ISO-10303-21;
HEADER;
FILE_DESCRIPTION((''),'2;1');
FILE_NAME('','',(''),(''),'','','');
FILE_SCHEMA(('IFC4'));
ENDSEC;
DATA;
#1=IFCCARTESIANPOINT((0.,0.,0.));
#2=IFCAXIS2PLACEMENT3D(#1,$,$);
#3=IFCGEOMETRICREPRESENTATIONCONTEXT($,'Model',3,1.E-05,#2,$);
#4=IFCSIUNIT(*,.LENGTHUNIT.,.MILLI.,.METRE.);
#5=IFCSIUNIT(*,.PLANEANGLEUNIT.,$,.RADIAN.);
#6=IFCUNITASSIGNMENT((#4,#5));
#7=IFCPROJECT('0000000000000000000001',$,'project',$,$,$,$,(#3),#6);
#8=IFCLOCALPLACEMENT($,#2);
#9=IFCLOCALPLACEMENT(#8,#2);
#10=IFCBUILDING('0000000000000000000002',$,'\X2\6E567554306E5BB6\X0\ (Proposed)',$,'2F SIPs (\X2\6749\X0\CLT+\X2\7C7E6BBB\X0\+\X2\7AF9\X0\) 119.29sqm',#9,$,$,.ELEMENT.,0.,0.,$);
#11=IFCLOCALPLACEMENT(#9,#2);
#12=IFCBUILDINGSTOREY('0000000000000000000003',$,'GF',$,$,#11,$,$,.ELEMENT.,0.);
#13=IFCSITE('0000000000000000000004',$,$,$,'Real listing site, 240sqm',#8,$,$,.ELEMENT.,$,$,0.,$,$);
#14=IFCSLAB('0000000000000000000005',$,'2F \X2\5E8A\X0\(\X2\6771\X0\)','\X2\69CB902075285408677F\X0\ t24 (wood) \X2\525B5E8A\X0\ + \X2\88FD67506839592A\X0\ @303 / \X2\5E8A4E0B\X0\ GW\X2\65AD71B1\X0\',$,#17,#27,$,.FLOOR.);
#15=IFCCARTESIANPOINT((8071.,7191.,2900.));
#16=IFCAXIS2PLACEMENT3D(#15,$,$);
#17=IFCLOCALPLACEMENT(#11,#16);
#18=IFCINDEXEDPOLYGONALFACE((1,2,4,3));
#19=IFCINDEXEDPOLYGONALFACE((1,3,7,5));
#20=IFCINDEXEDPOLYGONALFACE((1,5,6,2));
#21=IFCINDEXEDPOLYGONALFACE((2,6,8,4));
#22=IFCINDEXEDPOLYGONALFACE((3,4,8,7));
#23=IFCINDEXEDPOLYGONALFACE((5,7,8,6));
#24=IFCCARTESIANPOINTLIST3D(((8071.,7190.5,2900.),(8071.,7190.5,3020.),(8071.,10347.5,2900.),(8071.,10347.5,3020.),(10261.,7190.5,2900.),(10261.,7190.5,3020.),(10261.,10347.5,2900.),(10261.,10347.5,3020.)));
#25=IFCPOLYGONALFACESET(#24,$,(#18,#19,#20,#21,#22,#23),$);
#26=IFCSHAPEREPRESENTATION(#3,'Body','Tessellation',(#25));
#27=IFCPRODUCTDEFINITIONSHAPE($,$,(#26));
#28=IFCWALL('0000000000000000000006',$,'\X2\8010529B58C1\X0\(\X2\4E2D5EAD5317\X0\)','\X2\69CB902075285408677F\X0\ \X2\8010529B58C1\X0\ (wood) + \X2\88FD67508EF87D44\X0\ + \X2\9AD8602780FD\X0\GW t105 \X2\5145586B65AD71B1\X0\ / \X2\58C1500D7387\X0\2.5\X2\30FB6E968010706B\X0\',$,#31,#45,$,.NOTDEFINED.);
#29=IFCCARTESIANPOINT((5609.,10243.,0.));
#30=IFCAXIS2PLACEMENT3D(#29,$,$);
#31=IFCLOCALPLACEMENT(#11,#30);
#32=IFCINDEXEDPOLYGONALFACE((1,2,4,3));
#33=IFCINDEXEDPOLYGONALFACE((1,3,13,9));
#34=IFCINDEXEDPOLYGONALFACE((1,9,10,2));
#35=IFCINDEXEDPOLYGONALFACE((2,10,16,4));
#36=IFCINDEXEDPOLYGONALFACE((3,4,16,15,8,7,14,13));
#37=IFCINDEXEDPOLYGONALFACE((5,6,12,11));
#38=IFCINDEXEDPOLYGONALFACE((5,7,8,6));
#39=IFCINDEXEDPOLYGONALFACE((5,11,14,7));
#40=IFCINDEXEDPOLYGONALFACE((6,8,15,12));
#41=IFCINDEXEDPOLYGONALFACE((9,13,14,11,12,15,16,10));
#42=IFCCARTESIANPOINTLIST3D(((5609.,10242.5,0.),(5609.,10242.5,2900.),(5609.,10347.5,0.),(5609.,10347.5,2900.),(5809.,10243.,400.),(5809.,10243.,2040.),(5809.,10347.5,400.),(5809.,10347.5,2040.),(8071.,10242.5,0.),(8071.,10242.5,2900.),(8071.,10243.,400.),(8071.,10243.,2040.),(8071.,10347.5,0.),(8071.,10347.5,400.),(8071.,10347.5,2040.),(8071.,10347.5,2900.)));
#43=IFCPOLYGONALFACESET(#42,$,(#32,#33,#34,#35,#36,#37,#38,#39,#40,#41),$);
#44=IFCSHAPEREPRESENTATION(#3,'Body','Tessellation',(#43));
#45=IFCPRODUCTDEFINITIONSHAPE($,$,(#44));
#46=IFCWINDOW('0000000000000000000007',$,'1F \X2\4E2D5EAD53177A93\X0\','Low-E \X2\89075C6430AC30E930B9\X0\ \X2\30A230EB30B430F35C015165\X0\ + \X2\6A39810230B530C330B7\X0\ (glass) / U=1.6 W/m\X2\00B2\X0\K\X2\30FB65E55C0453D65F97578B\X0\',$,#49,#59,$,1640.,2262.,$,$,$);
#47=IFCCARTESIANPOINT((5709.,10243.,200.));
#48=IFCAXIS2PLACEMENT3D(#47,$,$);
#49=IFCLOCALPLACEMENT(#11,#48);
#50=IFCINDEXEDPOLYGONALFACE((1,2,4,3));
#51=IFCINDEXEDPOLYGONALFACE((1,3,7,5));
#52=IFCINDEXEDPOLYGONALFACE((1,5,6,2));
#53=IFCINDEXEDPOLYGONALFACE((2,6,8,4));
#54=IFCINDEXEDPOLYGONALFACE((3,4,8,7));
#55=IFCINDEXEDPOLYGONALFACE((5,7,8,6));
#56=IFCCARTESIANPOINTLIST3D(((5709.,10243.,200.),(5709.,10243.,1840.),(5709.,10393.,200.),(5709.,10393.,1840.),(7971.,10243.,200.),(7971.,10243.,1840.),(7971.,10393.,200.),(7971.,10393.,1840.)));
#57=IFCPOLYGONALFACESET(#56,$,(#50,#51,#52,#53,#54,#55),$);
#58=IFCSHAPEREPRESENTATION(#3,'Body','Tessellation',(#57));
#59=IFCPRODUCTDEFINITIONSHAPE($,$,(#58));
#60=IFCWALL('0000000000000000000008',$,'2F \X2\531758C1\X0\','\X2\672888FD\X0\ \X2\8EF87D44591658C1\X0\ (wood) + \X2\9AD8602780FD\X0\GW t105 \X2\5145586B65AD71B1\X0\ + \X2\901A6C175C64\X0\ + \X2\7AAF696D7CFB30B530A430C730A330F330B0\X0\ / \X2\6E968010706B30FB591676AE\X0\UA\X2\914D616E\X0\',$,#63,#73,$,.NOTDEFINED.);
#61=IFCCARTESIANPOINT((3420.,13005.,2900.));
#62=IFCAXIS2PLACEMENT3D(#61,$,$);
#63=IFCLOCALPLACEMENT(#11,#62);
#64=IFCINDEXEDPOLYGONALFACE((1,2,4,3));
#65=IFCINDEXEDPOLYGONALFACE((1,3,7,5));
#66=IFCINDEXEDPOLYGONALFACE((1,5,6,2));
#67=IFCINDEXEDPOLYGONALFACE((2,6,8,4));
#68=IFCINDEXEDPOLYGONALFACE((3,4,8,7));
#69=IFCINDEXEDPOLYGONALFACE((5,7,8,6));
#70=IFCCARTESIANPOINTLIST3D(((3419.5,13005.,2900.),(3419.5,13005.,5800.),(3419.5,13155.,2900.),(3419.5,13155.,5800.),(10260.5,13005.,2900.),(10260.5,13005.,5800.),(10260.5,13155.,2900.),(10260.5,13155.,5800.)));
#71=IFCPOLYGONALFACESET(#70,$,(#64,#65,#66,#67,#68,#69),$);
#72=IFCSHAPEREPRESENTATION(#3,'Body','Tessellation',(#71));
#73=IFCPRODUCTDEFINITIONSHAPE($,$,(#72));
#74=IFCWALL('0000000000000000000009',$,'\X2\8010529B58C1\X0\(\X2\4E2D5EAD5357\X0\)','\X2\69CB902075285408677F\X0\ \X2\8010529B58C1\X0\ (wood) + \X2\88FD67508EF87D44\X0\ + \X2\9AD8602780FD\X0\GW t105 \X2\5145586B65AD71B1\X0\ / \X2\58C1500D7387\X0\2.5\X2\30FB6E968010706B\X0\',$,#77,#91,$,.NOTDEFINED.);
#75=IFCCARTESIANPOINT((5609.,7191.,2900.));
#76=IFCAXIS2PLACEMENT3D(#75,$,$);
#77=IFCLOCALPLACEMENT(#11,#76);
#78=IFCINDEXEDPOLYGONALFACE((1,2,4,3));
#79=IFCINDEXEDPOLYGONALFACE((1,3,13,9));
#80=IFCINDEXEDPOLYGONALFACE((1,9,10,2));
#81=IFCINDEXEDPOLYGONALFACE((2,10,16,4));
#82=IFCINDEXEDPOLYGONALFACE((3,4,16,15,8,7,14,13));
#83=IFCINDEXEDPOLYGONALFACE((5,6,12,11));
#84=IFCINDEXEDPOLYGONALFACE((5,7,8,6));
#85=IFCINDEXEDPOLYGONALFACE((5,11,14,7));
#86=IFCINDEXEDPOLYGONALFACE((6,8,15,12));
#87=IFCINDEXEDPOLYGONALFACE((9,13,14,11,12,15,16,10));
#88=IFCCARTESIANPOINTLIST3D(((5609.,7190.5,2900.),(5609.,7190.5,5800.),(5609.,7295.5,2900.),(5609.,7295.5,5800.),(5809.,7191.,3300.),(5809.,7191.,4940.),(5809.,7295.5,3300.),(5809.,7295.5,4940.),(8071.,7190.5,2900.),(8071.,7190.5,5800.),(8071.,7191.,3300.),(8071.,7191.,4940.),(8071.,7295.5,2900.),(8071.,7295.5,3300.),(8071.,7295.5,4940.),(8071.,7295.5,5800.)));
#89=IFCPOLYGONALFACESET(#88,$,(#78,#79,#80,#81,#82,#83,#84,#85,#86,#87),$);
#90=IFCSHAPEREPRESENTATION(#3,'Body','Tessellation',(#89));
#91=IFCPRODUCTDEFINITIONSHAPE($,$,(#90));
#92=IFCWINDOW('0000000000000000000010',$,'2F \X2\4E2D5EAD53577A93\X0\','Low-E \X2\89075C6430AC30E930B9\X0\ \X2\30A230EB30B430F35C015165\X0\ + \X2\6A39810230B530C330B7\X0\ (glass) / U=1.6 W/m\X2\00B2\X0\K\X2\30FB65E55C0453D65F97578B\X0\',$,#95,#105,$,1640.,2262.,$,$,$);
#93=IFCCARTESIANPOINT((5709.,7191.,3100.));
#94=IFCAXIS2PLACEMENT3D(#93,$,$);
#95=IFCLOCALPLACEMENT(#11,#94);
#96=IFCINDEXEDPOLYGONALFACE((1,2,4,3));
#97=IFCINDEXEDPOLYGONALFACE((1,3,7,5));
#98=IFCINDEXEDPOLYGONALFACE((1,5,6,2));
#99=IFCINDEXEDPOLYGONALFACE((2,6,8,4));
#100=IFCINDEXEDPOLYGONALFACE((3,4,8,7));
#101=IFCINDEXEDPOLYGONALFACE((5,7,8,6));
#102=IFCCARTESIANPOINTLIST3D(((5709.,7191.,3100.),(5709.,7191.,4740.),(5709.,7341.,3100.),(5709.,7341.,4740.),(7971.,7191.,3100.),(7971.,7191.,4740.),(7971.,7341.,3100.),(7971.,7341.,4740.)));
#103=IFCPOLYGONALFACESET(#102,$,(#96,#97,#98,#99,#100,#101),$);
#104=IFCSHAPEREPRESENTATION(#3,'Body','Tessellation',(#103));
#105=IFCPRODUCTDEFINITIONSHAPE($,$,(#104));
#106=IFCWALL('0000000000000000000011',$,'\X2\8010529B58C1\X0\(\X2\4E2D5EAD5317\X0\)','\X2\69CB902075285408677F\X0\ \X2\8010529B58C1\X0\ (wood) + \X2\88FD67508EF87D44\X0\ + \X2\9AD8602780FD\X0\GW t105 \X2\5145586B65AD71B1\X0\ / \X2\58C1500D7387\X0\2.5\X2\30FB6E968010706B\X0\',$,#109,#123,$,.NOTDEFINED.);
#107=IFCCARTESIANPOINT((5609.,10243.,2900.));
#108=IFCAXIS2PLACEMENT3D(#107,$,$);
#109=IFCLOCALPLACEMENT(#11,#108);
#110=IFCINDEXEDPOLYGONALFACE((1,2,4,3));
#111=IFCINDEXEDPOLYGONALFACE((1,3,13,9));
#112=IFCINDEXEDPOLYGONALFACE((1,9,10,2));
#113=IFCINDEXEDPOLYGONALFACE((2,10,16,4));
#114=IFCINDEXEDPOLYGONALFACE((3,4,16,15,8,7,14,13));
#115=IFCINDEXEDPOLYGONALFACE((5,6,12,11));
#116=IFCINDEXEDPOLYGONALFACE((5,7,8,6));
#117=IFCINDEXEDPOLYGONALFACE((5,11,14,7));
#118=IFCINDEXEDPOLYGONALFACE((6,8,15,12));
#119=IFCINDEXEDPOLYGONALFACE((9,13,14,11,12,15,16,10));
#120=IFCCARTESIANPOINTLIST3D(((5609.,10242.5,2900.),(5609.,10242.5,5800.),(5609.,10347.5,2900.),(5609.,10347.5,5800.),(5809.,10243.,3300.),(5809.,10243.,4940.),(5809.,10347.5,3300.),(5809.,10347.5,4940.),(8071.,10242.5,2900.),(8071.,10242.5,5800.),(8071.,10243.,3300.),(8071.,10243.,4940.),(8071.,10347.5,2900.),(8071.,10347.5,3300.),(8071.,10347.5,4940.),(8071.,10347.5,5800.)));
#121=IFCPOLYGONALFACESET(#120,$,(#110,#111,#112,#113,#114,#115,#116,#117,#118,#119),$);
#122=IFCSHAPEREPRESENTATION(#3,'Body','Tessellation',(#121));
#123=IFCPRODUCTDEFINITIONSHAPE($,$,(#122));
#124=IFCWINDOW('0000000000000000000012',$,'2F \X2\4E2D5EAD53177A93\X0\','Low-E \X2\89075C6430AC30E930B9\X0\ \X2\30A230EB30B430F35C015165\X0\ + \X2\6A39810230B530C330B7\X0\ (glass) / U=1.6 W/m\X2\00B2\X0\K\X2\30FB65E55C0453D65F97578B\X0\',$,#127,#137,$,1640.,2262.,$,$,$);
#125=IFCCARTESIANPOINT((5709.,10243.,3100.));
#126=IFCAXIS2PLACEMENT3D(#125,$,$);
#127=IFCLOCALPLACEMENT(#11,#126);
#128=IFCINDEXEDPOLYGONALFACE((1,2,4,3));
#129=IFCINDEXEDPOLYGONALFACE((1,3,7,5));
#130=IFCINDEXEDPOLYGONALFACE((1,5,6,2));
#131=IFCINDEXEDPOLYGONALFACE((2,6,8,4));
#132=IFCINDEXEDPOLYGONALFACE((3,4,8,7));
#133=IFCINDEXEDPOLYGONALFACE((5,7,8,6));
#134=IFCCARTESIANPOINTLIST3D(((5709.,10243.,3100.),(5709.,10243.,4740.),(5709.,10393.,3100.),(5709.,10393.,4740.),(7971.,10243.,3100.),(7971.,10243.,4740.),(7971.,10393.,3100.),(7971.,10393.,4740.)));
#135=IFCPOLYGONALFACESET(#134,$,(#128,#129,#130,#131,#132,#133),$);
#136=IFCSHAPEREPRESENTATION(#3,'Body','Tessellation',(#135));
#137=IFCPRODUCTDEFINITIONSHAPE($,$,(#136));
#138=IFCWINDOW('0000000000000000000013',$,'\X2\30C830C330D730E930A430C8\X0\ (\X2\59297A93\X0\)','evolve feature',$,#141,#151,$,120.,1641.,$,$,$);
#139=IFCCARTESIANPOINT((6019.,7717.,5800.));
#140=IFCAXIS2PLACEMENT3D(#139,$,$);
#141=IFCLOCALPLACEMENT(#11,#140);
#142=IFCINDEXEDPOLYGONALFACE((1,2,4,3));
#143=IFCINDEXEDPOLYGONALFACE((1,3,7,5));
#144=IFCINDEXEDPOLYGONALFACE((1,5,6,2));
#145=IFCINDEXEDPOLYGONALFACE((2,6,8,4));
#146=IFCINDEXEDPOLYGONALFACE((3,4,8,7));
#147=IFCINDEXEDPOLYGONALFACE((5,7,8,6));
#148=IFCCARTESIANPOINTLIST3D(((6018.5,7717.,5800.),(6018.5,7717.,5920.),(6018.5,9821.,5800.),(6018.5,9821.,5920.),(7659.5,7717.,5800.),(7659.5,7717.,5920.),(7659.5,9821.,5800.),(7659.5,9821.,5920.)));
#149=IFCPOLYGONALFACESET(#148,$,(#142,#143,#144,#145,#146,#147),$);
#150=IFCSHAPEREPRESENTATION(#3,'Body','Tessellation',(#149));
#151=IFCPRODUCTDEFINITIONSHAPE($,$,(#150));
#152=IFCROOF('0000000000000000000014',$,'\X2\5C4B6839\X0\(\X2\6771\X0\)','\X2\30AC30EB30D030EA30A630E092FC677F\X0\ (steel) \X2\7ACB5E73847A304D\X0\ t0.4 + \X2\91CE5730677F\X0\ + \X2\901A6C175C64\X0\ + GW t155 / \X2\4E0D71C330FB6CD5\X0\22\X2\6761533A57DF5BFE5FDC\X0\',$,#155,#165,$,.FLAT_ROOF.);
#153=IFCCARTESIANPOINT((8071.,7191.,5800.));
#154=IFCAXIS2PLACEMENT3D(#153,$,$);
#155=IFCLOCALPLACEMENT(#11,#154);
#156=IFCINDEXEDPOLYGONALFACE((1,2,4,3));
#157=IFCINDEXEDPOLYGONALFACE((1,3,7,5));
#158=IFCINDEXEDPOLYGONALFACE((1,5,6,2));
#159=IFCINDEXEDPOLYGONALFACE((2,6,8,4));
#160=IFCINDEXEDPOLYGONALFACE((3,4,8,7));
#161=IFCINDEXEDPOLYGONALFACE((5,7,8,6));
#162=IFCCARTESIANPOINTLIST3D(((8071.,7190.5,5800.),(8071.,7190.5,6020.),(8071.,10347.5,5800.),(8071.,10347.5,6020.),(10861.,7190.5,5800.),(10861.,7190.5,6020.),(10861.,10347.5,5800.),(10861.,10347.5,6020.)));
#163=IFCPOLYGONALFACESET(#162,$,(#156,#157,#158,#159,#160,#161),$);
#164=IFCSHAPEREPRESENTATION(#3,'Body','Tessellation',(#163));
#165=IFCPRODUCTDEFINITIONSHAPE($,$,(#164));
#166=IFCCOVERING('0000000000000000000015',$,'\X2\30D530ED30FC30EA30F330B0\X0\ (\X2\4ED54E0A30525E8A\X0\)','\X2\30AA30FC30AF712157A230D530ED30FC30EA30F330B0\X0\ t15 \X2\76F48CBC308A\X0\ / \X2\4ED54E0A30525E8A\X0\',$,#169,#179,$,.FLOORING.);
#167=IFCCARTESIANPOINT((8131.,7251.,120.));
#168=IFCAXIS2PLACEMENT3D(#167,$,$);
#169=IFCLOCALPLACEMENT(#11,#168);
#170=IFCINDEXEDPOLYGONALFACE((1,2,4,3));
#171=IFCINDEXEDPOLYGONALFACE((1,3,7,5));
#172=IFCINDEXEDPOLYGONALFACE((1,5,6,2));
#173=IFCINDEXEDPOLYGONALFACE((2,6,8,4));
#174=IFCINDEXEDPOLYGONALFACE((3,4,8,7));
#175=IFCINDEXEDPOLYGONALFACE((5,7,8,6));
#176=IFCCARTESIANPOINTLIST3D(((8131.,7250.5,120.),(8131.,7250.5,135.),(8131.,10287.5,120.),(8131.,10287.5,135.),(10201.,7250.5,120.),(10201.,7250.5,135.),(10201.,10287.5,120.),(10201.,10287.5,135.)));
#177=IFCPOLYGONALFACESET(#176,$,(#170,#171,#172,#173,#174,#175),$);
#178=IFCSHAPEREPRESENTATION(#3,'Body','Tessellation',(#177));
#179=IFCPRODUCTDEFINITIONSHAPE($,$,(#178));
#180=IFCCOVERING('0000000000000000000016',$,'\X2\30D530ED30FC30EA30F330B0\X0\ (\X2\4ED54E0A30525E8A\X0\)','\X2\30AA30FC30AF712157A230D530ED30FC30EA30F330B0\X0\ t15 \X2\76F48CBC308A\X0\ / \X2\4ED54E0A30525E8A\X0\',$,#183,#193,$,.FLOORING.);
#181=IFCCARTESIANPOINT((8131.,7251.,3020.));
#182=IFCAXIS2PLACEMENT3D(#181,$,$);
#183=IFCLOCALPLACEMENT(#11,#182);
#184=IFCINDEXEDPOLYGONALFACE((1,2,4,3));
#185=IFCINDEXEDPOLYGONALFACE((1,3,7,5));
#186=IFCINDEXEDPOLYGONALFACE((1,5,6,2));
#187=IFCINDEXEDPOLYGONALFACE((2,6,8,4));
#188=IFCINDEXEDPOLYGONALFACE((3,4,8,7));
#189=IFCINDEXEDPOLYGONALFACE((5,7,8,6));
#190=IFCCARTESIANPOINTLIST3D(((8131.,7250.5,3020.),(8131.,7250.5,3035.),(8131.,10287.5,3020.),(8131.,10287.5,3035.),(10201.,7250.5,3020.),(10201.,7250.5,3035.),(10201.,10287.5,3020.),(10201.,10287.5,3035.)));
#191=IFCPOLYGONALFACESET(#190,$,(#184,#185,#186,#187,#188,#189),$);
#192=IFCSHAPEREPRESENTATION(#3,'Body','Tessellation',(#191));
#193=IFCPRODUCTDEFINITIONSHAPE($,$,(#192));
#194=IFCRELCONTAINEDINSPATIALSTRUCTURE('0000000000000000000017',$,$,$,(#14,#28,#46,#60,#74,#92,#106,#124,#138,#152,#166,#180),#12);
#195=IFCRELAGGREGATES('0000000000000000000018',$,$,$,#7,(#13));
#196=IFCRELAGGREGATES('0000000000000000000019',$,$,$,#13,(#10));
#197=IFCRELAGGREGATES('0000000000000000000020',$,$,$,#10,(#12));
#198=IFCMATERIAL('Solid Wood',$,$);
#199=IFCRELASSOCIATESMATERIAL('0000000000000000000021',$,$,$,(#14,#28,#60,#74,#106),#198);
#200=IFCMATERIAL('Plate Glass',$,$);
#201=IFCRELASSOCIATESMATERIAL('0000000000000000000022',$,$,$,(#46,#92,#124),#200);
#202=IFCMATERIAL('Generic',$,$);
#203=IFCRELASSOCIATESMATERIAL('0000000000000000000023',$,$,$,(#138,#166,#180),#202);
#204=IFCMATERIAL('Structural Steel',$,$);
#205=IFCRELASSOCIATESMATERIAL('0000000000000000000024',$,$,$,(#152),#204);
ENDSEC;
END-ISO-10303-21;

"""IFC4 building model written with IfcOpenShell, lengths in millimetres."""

from ifc_helpers import new_model, si_unit, frame, frame_2d, origin, place, context, project, spatial, rectangle, extrude, material, element, fill, save


model = new_model("IFC4")

# Units and contexts
model_context = context("Model", 3, precision=1e-05, world=origin())
ifc_project = project(units=[si_unit("LENGTHUNIT", "METRE", prefix="MILLI"), si_unit("PLANEANGLEUNIT", "RADIAN")], contexts=[model_context])

# Site, building, storey
site_placement = place(None, origin())
site = spatial("IfcSite", under=ifc_project, at=site_placement, ObjectType="Real listing site, 240sqm", CompositionType="ELEMENT", RefElevation=0.0)
building_placement = place(site_placement, origin())
building = spatial("IfcBuilding", under=site, at=building_placement, Name="湖畔の家 (Proposed)", ObjectType="2F SIPs (杉CLT+籾殻+竹) 119.29sqm", CompositionType="ELEMENT", ElevationOfRefHeight=0.0, ElevationOfTerrain=0.0)
storey_placement = place(building_placement, origin())
storey = spatial("IfcBuildingStorey", under=building, at=storey_placement, Name="GF", CompositionType="ELEMENT", Elevation=0.0)

# Slab
ifc_material_1 = material(Name="Solid Wood")
slab_1_placement = place(storey_placement, frame((8071.0, 7191.0, 2900.0)))
element("IfcSlab", 1, at=slab_1_placement, inside=storey, material=ifc_material_1, Name="2F 床(東)", Description="構造用合板 t24 (wood) 剛床 + 製材根太 @303 / 床下 GW断熱", PredefinedType="FLOOR", context=model_context, shape_type="SweptSolid", body=[
    extrude(rectangle(XDim=2190.0, YDim=3157.0, at=frame_2d((1095.0, 1578.0))), frame((8071.0, 7191.0, 2900.0)), (0.0, 0.0, 1.0), 120.0),
])

# Wall, opening, window
wall_1_placement = place(storey_placement, frame((5609.0, 10243.0, 0.0)))
wall_1 = element("IfcWall", 2, at=wall_1_placement, inside=storey, material=ifc_material_1, Name="耐力壁(中庭北)", Description="構造用合板 耐力壁 (wood) + 製材軸組 + 高性能GW t105 充填断熱 / 壁倍率2.5・準耐火", PredefinedType="NOTDEFINED", context=model_context, shape_type="SweptSolid", body=[
    extrude(rectangle(XDim=2462.0, YDim=105.0, at=frame_2d((1231.0, 52.0))), frame((5609.0, 10243.0, 0.0)), (0.0, 0.0, 1.0), 2900.0),
])
opening_1_placement = place(storey_placement, frame((5709.0, 10243.0, 200.0)))
opening_1 = element("IfcOpeningElement", 3, at=opening_1_placement, cuts=wall_1, PredefinedType="NOTDEFINED", context=model_context, shape_type="SweptSolid", body=[
    extrude(rectangle(XDim=2262.0, YDim=150.0, at=frame_2d((1131.0, 75.0))), frame((5709.0, 10243.0, 200.0)), (0.0, 0.0, 1.0), 1640.0),
])
ifc_material_2 = material(Name="Plate Glass")
window_1_placement = place(storey_placement, frame((5709.0, 10243.0, 200.0)))
window_1 = element("IfcWindow", 4, at=window_1_placement, inside=storey, material=ifc_material_2, Name="1F 中庭北窓", Description="Low-E 複層ガラス アルゴン封入 + 樹脂サッシ (glass) / U=1.6 W/m²K・日射取得型", OverallHeight=1640.0, OverallWidth=2262.0, context=model_context, shape_type="SweptSolid", body=[
    extrude(rectangle(XDim=2262.0, YDim=150.0, at=frame_2d((1131.0, 75.0))), frame((5709.0, 10243.0, 200.0)), (0.0, 0.0, 1.0), 1640.0),
])
fill(opening_1, window_1)

# Wall
wall_2_placement = place(storey_placement, frame((3420.0, 13005.0, 2900.0)))
element("IfcWall", 5, at=wall_2_placement, inside=storey, material=ifc_material_1, Name="2F 北壁", Description="木製 軸組外壁 (wood) + 高性能GW t105 充填断熱 + 通気層 + 窯業系サイディング / 準耐火・外皮UA配慮", PredefinedType="NOTDEFINED", context=model_context, shape_type="SweptSolid", body=[
    extrude(rectangle(XDim=6841.0, YDim=150.0, at=frame_2d((3420.0, 75.0))), frame((3420.0, 13005.0, 2900.0)), (0.0, 0.0, 1.0), 2900.0),
])

# Walls, openings, windows
wall_3_placement = place(storey_placement, frame((5609.0, 7191.0, 2900.0)))
wall_3 = element("IfcWall", 6, at=wall_3_placement, inside=storey, material=ifc_material_1, Name="耐力壁(中庭南)", Description="構造用合板 耐力壁 (wood) + 製材軸組 + 高性能GW t105 充填断熱 / 壁倍率2.5・準耐火", PredefinedType="NOTDEFINED", context=model_context, shape_type="SweptSolid", body=[
    extrude(rectangle(XDim=2462.0, YDim=105.0, at=frame_2d((1231.0, 52.0))), frame((5609.0, 7191.0, 2900.0)), (0.0, 0.0, 1.0), 2900.0),
])
opening_2_placement = place(storey_placement, frame((5709.0, 7191.0, 3100.0)))
opening_2 = element("IfcOpeningElement", 7, at=opening_2_placement, cuts=wall_3, PredefinedType="NOTDEFINED", context=model_context, shape_type="SweptSolid", body=[
    extrude(rectangle(XDim=2262.0, YDim=150.0, at=frame_2d((1131.0, 75.0))), frame((5709.0, 7191.0, 3100.0)), (0.0, 0.0, 1.0), 1640.0),
])
window_2_placement = place(storey_placement, frame((5709.0, 7191.0, 3100.0)))
window_2 = element("IfcWindow", 8, at=window_2_placement, inside=storey, material=ifc_material_2, Name="2F 中庭南窓", Description="Low-E 複層ガラス アルゴン封入 + 樹脂サッシ (glass) / U=1.6 W/m²K・日射取得型", OverallHeight=1640.0, OverallWidth=2262.0, context=model_context, shape_type="SweptSolid", body=[
    extrude(rectangle(XDim=2262.0, YDim=150.0, at=frame_2d((1131.0, 75.0))), frame((5709.0, 7191.0, 3100.0)), (0.0, 0.0, 1.0), 1640.0),
])
fill(opening_2, window_2)
wall_4_placement = place(storey_placement, frame((5609.0, 10243.0, 2900.0)))
wall_4 = element("IfcWall", 9, at=wall_4_placement, inside=storey, material=ifc_material_1, Name="耐力壁(中庭北)", Description="構造用合板 耐力壁 (wood) + 製材軸組 + 高性能GW t105 充填断熱 / 壁倍率2.5・準耐火", PredefinedType="NOTDEFINED", context=model_context, shape_type="SweptSolid", body=[
    extrude(rectangle(XDim=2462.0, YDim=105.0, at=frame_2d((1231.0, 52.0))), frame((5609.0, 10243.0, 2900.0)), (0.0, 0.0, 1.0), 2900.0),
])
opening_3_placement = place(storey_placement, frame((5709.0, 10243.0, 3100.0)))
opening_3 = element("IfcOpeningElement", 10, at=opening_3_placement, cuts=wall_4, PredefinedType="NOTDEFINED", context=model_context, shape_type="SweptSolid", body=[
    extrude(rectangle(XDim=2262.0, YDim=150.0, at=frame_2d((1131.0, 75.0))), frame((5709.0, 10243.0, 3100.0)), (0.0, 0.0, 1.0), 1640.0),
])
window_3_placement = place(storey_placement, frame((5709.0, 10243.0, 3100.0)))
window_3 = element("IfcWindow", 11, at=window_3_placement, inside=storey, material=ifc_material_2, Name="2F 中庭北窓", Description="Low-E 複層ガラス アルゴン封入 + 樹脂サッシ (glass) / U=1.6 W/m²K・日射取得型", OverallHeight=1640.0, OverallWidth=2262.0, context=model_context, shape_type="SweptSolid", body=[
    extrude(rectangle(XDim=2262.0, YDim=150.0, at=frame_2d((1131.0, 75.0))), frame((5709.0, 10243.0, 3100.0)), (0.0, 0.0, 1.0), 1640.0),
])
fill(opening_3, window_3)

# Window
ifc_material_3 = material(Name="Generic")
window_4_placement = place(storey_placement, frame((6019.0, 7717.0, 5800.0)))
element("IfcWindow", 12, at=window_4_placement, inside=storey, material=ifc_material_3, Name="トップライト (天窓)", Description="evolve feature", OverallHeight=120.0, OverallWidth=1641.0, context=model_context, shape_type="SweptSolid", body=[
    extrude(rectangle(XDim=1641.0, YDim=2104.0, at=frame_2d((820.0, 1052.0))), frame((6019.0, 7717.0, 5800.0)), (0.0, 0.0, 1.0), 120.0),
])

# Roof
ifc_material_4 = material(Name="Structural Steel")
roof_1_placement = place(storey_placement, frame((8071.0, 7191.0, 5800.0)))
element("IfcRoof", 13, at=roof_1_placement, inside=storey, material=ifc_material_4, Name="屋根(東)", Description="ガルバリウム鋼板 (steel) 立平葺き t0.4 + 野地板 + 通気層 + GW t155 / 不燃・法22条区域対応", PredefinedType="FLAT_ROOF", context=model_context, shape_type="SweptSolid", body=[
    extrude(rectangle(XDim=2790.0, YDim=3157.0, at=frame_2d((1395.0, 1578.0))), frame((8071.0, 7191.0, 5800.0)), (0.0, 0.0, 1.0), 220.0),
])

# Coverings
covering_1_placement = place(storey_placement, frame((8131.0, 7251.0, 120.0)))
element("IfcCovering", 14, at=covering_1_placement, inside=storey, material=ifc_material_3, Name="フローリング (仕上げ床)", Description="オーク無垢フローリング t15 直貼り / 仕上げ床", PredefinedType="FLOORING", context=model_context, shape_type="SweptSolid", body=[
    extrude(rectangle(XDim=2070.0, YDim=3037.0, at=frame_2d((1035.0, 1518.0))), frame((8131.0, 7251.0, 120.0)), (0.0, 0.0, 1.0), 15.0),
])
covering_2_placement = place(storey_placement, frame((8131.0, 7251.0, 3020.0)))
element("IfcCovering", 15, at=covering_2_placement, inside=storey, material=ifc_material_3, Name="フローリング (仕上げ床)", Description="オーク無垢フローリング t15 直貼り / 仕上げ床", PredefinedType="FLOORING", context=model_context, shape_type="SweptSolid", body=[
    extrude(rectangle(XDim=2070.0, YDim=3037.0, at=frame_2d((1035.0, 1518.0))), frame((8131.0, 7251.0, 3020.0)), (0.0, 0.0, 1.0), 15.0),
])

save(model, "model.ifc")
